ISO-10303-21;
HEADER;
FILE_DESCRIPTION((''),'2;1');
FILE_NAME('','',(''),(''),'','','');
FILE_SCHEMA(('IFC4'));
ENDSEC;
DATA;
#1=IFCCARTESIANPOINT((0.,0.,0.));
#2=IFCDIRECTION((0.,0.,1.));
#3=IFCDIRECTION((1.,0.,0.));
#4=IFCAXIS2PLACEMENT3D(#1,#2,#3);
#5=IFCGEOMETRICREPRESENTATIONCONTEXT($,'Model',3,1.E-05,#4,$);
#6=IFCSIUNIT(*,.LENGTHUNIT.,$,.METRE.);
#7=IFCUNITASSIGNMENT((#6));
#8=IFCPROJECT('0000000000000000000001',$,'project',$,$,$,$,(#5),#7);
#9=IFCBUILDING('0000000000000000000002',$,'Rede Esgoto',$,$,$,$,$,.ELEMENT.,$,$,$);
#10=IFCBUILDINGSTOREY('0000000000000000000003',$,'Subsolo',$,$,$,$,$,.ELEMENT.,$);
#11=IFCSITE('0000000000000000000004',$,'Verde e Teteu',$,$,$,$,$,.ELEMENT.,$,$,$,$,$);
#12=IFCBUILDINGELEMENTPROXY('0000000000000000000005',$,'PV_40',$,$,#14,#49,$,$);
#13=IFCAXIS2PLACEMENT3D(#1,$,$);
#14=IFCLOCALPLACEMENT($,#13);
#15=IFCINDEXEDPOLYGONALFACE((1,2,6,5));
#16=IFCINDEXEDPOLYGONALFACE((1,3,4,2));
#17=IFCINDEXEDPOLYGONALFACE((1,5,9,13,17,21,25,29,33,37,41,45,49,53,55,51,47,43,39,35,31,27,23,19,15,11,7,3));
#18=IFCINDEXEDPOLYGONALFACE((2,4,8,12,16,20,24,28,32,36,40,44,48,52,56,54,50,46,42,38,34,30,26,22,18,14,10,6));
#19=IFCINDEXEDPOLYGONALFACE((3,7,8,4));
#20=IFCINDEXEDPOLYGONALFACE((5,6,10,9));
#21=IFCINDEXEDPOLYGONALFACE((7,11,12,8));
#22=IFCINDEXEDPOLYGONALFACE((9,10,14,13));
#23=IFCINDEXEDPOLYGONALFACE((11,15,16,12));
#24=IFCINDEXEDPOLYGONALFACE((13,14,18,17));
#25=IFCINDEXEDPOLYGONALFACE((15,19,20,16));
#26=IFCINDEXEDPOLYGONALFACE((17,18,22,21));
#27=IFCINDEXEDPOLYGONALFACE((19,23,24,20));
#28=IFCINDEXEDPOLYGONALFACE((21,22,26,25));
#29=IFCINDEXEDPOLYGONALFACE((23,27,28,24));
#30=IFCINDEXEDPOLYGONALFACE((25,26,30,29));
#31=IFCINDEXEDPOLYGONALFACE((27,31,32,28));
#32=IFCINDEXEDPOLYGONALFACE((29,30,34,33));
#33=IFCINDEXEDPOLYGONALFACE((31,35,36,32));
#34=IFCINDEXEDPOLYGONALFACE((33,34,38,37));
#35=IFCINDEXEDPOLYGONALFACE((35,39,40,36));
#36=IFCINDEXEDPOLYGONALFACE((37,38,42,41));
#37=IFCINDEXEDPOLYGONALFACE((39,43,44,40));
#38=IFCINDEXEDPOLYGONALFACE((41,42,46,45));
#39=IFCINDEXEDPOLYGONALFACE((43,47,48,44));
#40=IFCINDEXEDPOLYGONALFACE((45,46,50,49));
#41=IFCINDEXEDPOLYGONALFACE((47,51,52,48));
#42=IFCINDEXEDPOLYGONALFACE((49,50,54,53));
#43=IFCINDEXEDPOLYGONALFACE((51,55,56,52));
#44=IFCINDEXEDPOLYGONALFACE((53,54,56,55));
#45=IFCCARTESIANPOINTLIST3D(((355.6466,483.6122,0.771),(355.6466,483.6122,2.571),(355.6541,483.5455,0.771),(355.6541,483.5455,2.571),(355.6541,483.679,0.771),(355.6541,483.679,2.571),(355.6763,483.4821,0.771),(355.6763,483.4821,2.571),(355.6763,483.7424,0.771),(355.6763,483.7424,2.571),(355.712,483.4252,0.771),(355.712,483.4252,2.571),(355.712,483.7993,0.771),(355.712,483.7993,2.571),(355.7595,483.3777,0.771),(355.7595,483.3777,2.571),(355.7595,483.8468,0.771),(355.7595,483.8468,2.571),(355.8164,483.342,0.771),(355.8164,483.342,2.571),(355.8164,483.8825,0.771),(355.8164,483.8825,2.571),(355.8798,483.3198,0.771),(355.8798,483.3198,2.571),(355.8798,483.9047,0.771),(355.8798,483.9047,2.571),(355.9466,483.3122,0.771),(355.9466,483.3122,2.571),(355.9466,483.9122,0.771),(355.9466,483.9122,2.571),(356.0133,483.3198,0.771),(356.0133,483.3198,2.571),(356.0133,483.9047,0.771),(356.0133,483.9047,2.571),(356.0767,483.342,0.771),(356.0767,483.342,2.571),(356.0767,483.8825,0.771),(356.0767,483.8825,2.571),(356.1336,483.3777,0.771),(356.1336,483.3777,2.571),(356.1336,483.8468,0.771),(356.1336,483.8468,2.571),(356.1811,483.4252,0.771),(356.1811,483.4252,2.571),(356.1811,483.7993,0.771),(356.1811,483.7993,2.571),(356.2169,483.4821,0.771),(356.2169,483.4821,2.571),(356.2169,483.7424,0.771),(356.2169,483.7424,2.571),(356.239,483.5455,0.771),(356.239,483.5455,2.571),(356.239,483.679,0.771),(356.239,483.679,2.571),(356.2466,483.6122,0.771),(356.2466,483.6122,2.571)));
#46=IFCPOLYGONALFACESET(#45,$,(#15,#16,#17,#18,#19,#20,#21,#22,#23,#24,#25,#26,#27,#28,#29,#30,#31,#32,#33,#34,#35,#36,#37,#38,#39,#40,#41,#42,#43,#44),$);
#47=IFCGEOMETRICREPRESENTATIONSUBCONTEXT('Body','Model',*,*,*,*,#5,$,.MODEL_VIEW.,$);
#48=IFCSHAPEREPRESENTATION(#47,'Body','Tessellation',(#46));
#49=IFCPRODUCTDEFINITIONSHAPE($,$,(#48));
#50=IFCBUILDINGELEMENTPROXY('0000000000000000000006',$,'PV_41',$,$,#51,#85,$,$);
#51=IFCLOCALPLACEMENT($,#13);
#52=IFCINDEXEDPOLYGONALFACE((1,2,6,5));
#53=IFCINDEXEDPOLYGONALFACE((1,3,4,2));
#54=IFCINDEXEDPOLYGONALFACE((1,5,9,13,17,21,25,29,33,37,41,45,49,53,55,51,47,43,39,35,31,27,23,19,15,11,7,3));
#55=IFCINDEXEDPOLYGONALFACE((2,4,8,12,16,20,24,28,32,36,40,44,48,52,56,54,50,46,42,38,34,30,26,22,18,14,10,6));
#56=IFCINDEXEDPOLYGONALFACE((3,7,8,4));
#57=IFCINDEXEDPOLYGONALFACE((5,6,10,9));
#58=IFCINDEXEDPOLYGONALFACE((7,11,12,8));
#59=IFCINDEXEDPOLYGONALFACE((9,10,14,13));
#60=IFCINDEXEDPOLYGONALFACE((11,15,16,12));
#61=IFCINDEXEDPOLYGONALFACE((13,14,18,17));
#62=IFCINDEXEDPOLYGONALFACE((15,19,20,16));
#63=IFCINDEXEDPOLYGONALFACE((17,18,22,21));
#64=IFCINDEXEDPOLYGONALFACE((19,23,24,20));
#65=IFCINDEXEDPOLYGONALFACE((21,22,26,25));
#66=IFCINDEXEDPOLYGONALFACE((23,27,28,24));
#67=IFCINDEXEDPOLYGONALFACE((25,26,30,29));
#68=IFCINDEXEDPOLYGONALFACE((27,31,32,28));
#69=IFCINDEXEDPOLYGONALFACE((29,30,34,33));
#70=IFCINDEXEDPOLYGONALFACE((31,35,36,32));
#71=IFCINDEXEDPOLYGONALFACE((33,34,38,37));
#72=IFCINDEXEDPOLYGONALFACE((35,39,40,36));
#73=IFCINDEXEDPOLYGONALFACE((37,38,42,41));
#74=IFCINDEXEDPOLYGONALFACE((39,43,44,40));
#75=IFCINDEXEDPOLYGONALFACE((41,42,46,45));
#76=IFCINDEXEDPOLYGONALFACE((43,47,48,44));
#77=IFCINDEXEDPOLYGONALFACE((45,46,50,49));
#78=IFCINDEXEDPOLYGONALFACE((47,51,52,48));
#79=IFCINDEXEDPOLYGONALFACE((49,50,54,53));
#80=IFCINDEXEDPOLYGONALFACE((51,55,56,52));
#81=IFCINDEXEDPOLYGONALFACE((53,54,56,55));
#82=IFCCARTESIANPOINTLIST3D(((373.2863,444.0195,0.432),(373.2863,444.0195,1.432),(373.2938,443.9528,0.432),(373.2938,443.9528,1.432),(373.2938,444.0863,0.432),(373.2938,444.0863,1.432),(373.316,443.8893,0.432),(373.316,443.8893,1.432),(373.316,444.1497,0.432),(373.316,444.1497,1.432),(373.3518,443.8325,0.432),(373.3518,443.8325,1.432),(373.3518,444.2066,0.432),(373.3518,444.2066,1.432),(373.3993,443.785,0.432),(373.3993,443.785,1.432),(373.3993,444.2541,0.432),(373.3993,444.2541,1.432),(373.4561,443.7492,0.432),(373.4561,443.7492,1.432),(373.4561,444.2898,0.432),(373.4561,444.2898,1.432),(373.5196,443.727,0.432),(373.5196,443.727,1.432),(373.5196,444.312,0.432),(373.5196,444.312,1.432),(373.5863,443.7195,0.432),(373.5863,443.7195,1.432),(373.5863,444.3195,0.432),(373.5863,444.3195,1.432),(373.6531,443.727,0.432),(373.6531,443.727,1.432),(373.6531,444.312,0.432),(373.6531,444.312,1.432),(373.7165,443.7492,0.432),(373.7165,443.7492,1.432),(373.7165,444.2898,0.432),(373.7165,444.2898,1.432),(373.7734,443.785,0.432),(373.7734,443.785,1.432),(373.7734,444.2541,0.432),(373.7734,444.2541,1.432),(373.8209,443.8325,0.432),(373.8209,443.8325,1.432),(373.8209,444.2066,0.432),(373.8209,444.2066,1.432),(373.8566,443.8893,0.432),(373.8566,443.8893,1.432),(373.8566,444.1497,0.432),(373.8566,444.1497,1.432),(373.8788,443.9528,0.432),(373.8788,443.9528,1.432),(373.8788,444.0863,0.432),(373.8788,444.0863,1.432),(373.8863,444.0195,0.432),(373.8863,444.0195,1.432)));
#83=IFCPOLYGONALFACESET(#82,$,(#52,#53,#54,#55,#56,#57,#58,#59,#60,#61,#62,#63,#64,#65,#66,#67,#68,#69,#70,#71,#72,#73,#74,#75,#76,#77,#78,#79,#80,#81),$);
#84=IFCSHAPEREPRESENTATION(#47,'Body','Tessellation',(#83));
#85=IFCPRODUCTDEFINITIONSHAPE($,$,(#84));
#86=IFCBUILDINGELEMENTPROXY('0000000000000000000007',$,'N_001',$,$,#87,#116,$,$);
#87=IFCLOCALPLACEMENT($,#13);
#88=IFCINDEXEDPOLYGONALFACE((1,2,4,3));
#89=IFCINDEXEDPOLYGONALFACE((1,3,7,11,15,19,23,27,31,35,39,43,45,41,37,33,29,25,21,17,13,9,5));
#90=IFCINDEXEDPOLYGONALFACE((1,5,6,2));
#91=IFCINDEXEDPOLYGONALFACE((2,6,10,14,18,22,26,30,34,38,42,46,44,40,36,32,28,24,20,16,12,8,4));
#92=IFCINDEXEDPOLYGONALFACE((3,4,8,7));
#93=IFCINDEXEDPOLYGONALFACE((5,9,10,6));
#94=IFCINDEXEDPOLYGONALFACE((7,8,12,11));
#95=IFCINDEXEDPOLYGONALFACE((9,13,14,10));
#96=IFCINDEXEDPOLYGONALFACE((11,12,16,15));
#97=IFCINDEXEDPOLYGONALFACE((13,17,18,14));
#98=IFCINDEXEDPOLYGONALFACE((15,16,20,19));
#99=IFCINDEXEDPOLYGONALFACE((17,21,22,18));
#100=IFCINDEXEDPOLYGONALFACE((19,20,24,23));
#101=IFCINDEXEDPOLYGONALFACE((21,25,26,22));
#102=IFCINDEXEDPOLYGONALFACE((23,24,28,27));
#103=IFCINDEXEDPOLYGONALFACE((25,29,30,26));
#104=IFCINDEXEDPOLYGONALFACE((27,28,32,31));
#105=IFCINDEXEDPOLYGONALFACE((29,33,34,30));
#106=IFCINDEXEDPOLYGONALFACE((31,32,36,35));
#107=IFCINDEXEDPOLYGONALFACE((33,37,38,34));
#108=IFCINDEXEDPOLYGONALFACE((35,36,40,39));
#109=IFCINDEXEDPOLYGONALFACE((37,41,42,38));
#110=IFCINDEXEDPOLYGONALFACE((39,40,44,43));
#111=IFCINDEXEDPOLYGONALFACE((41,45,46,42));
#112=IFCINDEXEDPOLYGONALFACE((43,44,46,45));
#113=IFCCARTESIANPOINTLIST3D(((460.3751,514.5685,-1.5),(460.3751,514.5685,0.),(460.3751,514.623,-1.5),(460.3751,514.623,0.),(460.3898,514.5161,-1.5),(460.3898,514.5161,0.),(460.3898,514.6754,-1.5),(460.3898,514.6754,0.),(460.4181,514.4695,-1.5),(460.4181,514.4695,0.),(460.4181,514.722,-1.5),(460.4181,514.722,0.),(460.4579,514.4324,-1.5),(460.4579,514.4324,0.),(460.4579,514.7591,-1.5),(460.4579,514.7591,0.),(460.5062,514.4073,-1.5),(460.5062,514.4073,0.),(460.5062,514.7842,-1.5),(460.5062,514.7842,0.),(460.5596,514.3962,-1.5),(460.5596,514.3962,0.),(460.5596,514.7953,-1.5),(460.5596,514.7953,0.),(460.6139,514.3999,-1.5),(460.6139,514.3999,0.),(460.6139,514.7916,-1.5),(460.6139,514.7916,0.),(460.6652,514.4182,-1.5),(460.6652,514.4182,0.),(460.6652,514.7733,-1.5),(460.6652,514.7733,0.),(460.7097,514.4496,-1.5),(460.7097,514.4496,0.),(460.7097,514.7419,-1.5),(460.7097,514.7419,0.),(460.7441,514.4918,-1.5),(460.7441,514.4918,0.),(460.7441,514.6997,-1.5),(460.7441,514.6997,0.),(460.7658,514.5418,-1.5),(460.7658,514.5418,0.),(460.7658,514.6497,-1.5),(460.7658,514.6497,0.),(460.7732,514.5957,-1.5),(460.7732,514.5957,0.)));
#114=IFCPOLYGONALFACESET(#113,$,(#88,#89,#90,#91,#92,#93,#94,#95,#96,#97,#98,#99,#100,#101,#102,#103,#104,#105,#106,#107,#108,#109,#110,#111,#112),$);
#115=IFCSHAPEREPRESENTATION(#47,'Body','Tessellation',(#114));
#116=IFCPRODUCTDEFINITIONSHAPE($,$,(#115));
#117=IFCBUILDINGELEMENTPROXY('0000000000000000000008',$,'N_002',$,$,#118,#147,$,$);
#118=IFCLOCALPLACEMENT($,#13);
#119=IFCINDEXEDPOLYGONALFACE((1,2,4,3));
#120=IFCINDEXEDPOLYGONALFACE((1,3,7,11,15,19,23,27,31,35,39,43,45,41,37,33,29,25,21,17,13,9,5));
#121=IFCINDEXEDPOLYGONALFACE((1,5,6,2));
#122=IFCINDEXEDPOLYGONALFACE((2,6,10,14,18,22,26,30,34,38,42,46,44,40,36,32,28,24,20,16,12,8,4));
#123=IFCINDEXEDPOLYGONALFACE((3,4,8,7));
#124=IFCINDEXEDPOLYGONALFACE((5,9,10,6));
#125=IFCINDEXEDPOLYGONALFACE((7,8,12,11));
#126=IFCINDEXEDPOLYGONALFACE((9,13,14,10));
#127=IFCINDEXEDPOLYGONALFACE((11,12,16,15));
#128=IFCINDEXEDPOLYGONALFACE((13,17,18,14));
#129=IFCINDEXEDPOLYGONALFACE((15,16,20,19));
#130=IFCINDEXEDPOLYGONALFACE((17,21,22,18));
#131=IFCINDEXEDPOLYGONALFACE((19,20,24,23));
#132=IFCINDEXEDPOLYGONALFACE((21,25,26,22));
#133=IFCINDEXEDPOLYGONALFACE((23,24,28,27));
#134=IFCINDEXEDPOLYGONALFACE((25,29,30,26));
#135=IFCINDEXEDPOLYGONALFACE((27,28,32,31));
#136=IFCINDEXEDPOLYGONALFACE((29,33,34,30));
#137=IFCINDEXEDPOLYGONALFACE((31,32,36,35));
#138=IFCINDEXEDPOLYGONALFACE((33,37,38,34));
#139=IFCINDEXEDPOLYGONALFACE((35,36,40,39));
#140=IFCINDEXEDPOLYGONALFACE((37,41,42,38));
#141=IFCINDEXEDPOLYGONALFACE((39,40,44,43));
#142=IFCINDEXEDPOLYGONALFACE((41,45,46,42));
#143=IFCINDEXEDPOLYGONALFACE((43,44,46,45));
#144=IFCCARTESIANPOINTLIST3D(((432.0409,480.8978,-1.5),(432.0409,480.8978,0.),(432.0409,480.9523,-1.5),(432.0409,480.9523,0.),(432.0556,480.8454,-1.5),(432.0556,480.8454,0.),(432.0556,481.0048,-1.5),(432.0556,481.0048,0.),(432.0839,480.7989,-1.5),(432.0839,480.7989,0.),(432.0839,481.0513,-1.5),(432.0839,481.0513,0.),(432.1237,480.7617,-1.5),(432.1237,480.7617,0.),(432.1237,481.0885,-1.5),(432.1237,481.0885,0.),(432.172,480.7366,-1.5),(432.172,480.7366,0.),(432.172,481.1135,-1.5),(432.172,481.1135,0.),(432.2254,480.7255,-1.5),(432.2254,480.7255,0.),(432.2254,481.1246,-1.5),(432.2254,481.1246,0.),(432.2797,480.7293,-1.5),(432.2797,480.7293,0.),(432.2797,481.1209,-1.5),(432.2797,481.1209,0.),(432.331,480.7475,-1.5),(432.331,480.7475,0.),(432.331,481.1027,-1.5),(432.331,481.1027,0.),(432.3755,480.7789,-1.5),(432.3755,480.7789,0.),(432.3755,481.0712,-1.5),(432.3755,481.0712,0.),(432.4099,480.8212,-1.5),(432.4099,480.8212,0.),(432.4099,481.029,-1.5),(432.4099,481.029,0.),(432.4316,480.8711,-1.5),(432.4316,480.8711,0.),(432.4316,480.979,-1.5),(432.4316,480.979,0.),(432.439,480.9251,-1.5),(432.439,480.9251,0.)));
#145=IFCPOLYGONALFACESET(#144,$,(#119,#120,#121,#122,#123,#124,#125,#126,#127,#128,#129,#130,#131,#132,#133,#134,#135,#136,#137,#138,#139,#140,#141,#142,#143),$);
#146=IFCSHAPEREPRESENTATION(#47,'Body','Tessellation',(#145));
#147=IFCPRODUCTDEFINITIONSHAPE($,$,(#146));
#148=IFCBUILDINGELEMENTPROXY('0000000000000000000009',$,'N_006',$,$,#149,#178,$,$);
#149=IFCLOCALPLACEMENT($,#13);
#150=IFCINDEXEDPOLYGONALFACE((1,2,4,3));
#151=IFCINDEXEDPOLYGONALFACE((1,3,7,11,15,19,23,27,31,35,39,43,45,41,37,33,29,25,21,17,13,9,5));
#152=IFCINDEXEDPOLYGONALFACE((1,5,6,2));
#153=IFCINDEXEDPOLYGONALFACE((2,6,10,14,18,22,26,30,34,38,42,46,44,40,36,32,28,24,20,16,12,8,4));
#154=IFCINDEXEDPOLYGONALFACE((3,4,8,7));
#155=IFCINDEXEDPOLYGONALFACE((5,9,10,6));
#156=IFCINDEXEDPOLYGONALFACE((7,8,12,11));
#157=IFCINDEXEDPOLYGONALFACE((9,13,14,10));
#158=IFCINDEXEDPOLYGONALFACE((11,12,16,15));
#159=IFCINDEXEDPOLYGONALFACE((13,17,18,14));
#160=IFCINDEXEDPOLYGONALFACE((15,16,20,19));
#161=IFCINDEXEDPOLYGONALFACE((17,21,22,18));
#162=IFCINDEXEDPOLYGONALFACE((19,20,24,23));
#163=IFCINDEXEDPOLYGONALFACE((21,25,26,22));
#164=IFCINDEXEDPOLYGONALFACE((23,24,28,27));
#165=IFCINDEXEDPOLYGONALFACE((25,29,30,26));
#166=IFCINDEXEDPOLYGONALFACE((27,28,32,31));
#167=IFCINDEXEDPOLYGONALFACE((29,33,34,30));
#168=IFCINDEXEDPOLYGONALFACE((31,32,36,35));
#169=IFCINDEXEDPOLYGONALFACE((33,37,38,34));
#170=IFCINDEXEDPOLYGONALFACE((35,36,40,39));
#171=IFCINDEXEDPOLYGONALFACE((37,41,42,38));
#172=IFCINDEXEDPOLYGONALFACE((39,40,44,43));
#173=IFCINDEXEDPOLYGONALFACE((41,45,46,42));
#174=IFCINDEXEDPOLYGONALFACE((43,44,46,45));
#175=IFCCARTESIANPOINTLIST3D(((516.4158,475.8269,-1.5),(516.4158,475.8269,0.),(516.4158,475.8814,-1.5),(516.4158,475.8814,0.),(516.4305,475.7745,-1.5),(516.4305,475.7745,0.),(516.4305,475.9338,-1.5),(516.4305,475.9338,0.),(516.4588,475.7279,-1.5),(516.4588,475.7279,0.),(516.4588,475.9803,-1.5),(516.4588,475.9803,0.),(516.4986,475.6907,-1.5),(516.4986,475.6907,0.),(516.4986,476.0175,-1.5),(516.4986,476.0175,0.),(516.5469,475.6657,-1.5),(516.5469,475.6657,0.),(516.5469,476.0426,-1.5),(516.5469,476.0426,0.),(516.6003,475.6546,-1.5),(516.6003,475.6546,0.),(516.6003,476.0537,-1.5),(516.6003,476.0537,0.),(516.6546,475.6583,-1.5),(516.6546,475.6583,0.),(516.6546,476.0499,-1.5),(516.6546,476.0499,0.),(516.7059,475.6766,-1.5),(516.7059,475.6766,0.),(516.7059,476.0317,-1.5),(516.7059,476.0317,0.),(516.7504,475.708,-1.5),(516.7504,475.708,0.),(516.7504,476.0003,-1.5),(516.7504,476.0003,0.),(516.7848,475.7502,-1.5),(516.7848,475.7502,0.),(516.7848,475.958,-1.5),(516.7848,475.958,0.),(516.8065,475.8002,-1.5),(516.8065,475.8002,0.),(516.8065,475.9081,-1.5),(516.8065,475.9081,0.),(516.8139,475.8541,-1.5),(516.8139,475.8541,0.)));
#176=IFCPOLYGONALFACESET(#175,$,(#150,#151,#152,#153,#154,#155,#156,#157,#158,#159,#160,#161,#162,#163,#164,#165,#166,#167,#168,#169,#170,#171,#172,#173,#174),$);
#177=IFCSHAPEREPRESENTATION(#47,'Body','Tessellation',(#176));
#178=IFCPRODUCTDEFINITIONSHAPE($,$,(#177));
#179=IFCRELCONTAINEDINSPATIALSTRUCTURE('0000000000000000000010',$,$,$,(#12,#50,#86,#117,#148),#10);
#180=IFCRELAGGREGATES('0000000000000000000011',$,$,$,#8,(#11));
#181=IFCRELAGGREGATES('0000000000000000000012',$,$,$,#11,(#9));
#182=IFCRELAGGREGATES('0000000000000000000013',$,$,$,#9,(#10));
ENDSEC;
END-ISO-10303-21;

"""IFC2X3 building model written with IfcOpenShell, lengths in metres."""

from ifc_helpers import new_model, si_unit, frame, origin_with_axes, origin_2d, place, context, subcontext, project, spatial, circle, extrude, element, save


model = new_model("IFC2X3")

# Units and contexts
model_context = context("Model", 3, precision=1e-05, world=origin_with_axes())
body_context = subcontext(model_context, "Body", "Model", "MODEL_VIEW")
ifc_project = project(units=[si_unit("LENGTHUNIT", "METRE")], contexts=[model_context])

# Site, building, storey
site = spatial("IfcSite", under=ifc_project, Name="Verde e Teteu", CompositionType="ELEMENT")
building = spatial("IfcBuilding", under=site, Name="Rede Esgoto", CompositionType="ELEMENT")
storey = spatial("IfcBuildingStorey", under=building, Name="Subsolo", CompositionType="ELEMENT")

# Building element proxies
proxy_1_placement = place(None, frame((355.9466, 483.6122, 0.771), z_axis=(0.0, 0.0, 1.0), x_axis=(1.0, 0.0, 0.0)))
element("IfcBuildingElementProxy", 1, at=proxy_1_placement, inside=storey, Name="PV_40", context=body_context, shape_type="SweptSolid", body=[
    extrude(circle(Radius=0.3, at=origin_2d()), origin_with_axes(), (0.0, 0.0, 1.0), 1.8),
])
proxy_2_placement = place(None, frame((373.5863, 444.0195, 0.432), z_axis=(0.0, 0.0, 1.0), x_axis=(1.0, 0.0, 0.0)))
element("IfcBuildingElementProxy", 2, at=proxy_2_placement, inside=storey, Name="PV_41", context=body_context, shape_type="SweptSolid", body=[
    extrude(circle(Radius=0.3, at=origin_2d()), origin_with_axes(), (0.0, 0.0, 1.0), 1.0),
])
for number, where, z_axis, x_axis, name in (
    (3, (460.5732, 514.5957, -1.5), (0.0, 0.0, 1.0), (1.0, 0.0, 0.0), "N_001"),
    (4, (432.239, 480.9251, -1.5), (0.0, 0.0, 1.0), (1.0, 0.0, 0.0), "N_002"),
    (5, (516.6139, 475.8541, -1.5), (0.0, 0.0, 1.0), (1.0, 0.0, 0.0), "N_006"),
):
    element("IfcBuildingElementProxy", number, at=place(None, frame(where, z_axis=z_axis, x_axis=x_axis)), inside=storey, Name=name, context=body_context, shape_type="SweptSolid", body=[
        extrude(circle(Radius=0.2, at=origin_2d()), origin_with_axes(), (0.0, 0.0, 1.0), 1.5),
    ])

save(model, "model.ifc")
